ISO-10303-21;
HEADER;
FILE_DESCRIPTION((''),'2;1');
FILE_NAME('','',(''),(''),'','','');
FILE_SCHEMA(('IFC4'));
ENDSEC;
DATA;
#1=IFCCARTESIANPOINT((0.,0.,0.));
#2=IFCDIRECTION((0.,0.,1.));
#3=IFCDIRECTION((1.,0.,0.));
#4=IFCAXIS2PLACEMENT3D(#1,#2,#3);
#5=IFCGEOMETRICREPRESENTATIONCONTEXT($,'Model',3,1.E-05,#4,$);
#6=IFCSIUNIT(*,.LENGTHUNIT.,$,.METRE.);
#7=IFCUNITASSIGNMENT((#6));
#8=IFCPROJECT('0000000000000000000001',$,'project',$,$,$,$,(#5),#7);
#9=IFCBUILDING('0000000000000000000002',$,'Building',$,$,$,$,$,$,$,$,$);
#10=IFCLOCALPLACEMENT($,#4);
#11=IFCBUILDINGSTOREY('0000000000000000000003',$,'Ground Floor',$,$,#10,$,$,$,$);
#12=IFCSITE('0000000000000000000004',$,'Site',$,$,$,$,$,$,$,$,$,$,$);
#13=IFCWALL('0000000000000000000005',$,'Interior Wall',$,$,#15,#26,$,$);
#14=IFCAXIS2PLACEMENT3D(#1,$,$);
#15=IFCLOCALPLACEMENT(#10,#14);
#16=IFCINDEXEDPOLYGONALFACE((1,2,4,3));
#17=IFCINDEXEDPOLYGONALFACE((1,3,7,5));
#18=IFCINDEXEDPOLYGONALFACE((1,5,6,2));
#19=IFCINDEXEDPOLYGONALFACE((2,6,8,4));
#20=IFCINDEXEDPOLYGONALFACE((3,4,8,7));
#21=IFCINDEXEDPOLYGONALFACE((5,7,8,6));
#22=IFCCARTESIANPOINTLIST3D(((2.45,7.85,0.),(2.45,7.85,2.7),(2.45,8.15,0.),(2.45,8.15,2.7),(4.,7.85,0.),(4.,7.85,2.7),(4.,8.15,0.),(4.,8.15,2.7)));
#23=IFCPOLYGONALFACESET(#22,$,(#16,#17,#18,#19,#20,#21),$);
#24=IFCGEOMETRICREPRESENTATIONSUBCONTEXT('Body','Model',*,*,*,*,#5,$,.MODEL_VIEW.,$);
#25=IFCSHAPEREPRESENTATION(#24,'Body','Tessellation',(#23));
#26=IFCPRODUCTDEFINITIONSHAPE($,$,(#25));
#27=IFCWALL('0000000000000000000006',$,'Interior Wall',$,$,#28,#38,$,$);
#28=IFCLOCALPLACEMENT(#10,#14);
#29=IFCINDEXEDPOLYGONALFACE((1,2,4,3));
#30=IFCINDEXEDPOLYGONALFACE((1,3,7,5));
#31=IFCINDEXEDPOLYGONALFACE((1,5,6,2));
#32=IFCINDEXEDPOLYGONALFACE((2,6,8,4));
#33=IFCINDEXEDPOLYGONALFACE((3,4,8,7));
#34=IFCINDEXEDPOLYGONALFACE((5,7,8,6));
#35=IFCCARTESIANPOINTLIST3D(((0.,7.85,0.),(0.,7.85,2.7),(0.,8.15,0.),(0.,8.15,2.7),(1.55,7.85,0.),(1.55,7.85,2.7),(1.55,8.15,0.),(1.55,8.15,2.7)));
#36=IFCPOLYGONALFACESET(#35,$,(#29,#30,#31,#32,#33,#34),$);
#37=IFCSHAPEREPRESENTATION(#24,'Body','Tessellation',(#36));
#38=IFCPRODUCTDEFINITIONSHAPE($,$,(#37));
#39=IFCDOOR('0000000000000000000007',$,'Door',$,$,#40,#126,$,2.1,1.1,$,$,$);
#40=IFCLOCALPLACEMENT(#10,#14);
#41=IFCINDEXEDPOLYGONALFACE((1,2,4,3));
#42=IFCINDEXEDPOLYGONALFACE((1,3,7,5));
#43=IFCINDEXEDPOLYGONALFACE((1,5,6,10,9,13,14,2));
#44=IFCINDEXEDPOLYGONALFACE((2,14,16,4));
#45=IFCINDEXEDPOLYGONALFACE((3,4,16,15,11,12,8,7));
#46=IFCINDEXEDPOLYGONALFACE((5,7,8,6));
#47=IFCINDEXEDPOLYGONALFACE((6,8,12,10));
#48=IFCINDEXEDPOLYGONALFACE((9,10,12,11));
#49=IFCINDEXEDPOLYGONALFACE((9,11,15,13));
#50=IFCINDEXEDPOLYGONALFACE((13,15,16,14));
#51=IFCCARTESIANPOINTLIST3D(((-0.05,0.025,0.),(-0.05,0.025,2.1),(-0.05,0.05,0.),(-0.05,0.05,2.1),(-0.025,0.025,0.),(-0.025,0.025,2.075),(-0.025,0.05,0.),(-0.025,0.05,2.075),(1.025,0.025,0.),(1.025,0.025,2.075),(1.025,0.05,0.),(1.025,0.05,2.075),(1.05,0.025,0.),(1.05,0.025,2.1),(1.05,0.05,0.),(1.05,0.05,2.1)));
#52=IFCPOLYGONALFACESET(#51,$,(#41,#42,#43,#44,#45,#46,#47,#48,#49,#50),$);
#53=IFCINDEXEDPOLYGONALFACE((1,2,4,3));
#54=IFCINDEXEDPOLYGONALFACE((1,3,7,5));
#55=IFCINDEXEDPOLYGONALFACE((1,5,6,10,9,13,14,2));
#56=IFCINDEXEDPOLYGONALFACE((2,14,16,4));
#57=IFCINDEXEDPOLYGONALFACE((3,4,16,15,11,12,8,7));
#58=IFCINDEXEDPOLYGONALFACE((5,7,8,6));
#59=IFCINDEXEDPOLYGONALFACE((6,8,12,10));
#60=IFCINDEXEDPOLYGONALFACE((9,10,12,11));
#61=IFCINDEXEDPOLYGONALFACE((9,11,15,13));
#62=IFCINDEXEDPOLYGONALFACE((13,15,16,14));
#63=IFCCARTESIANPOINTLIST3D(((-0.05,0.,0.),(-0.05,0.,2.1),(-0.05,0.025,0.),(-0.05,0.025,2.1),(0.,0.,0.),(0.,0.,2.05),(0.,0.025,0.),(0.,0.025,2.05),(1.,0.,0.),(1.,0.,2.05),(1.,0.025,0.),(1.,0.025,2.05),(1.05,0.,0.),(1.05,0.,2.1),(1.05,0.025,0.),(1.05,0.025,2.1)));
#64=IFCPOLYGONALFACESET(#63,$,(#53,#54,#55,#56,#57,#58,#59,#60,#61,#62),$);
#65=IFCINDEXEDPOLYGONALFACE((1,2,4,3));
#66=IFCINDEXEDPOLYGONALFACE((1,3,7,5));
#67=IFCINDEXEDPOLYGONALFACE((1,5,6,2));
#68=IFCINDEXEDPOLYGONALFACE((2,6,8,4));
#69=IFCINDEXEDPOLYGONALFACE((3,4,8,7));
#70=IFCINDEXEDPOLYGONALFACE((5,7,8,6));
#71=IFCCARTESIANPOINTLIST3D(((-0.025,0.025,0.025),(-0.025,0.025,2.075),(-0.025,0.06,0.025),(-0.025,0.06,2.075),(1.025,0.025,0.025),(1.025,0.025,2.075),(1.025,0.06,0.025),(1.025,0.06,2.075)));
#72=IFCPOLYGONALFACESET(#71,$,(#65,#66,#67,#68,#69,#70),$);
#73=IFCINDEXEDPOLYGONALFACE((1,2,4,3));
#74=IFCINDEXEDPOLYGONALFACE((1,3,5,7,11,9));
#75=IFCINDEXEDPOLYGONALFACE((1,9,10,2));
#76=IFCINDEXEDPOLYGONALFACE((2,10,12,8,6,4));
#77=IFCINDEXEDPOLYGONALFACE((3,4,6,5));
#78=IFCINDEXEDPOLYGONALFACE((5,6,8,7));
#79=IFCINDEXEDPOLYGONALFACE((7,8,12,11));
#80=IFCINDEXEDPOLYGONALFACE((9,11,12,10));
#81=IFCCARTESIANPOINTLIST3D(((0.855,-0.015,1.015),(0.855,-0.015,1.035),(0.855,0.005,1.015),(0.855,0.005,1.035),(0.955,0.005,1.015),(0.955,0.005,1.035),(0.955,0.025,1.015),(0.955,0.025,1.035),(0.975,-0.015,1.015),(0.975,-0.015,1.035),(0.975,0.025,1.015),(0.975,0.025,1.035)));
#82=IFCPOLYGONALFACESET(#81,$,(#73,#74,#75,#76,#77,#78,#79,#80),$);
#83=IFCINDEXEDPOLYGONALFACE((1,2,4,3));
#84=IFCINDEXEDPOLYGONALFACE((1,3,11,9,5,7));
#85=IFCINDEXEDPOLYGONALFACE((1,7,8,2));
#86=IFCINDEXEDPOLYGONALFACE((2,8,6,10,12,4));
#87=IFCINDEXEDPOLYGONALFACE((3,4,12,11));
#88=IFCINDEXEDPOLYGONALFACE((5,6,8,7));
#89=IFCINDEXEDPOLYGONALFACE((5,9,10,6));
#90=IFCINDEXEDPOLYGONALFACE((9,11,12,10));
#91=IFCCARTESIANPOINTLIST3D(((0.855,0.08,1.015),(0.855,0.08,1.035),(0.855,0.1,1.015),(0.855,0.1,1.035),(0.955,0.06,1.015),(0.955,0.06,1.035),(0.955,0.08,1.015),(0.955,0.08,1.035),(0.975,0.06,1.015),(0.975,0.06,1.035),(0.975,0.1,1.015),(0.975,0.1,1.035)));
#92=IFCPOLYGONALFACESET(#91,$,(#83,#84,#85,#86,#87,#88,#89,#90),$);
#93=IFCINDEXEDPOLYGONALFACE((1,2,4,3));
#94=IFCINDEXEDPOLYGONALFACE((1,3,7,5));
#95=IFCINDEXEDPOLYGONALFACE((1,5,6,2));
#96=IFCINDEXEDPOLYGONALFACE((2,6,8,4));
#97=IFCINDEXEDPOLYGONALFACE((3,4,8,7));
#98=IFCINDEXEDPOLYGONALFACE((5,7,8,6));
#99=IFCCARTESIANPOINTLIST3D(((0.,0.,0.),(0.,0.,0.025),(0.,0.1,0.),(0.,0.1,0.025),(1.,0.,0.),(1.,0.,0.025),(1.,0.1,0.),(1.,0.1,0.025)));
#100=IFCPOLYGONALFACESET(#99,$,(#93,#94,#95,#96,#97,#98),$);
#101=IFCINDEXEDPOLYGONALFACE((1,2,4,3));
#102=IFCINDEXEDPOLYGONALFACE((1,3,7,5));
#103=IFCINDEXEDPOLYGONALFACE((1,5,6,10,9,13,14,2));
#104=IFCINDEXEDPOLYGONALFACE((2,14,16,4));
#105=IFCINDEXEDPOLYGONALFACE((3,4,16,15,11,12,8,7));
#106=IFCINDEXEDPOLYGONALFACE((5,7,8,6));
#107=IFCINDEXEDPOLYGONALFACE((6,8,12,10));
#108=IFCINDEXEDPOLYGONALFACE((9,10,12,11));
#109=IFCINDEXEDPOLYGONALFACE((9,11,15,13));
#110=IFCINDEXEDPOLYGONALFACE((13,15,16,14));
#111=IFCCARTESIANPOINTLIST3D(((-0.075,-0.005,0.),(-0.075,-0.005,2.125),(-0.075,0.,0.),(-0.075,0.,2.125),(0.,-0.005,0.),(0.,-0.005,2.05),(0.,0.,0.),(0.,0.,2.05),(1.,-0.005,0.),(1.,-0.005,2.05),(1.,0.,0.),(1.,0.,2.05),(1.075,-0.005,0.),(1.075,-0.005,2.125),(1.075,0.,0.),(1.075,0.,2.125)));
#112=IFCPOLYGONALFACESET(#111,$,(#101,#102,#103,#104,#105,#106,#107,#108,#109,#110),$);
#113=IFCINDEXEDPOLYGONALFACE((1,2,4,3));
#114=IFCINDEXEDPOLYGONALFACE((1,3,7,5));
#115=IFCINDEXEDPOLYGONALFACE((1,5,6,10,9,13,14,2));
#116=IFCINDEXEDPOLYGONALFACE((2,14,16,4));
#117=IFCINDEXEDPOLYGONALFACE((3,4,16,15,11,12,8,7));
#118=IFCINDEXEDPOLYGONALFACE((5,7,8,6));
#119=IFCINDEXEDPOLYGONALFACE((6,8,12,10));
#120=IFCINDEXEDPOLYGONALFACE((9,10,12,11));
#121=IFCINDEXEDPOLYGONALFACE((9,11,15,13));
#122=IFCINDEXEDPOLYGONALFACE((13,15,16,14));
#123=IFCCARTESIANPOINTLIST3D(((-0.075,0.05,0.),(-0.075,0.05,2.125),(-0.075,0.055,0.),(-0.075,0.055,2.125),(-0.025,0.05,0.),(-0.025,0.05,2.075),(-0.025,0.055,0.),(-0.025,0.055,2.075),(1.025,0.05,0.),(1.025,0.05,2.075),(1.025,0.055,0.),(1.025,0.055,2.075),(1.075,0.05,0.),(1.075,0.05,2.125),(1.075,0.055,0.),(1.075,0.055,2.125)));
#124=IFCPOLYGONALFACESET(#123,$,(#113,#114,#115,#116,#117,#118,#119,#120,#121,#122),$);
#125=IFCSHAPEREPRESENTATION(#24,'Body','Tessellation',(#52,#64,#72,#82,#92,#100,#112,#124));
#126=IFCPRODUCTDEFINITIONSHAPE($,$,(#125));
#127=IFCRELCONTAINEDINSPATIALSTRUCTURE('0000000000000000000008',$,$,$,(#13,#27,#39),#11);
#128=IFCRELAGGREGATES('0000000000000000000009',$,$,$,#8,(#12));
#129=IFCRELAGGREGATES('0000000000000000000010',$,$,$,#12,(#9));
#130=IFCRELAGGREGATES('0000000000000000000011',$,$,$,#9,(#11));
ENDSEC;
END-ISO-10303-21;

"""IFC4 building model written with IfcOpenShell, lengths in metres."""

from ifc_helpers import new_model, si_unit, frame, origin_with_axes, place, context, subcontext, project, spatial, line, indexed_curve, outline, extrude, element, save


model = new_model("IFC4")

# Units and contexts
model_context = context("Model", 3, precision=1e-05, world=origin_with_axes())
body_context = subcontext(model_context, "Body", "Model", "MODEL_VIEW")
ifc_project = project(units=[si_unit("LENGTHUNIT", "METRE")], contexts=[model_context])

# Site, building, storey
site = spatial("IfcSite", under=ifc_project, Name="Site")
building = spatial("IfcBuilding", under=site, Name="Building")
storey_placement = place(None, origin_with_axes())
storey = spatial("IfcBuildingStorey", under=building, at=storey_placement, Name="Ground Floor")

# Walls
for number, where, z_axis, x_axis, name in (
    (1, (4.0, 8.0, 0.0), (0.0, 0.0, 1.0), (-1.0, 0.0, 0.0), "Interior Wall"),
    (2, (1.55, 8.0, 0.0), (0.0, 0.0, 1.0), (-1.0, 0.0, 0.0), "Interior Wall"),
):
    element("IfcWall", number, at=place(storey_placement, frame(where, z_axis=z_axis, x_axis=x_axis)), inside=storey, Name=name, context=body_context, shape_type="SweptSolid", body=[
        extrude(outline(indexed_curve([(0.0, 0.0), (0.0, 0.3), (1.55, 0.3), (1.55, 0.0), (0.0, 0.0)], self_intersect=False)), frame((0.0, -0.15, 0.0), z_axis=(0.0, 0.0, 1.0), x_axis=(1.0, 0.0, 0.0)), (0.0, 0.0, 1.0), 2.7),
    ])

# Door
door_1_placement = place(storey_placement, frame((-0.05, 0.0, 0.0), z_axis=(0.0, 0.0, 1.0), x_axis=(1.0, 0.0, 0.0)))
element("IfcDoor", 3, at=door_1_placement, inside=storey, Name="Door", OverallHeight=2.1, OverallWidth=1.1, context=body_context, shape_type="SweptSolid", body=[
    extrude(outline(indexed_curve([(0.0, 0.0), (0.0, 2.1), (1.1, 2.1), (1.1, 0.0), (1.075, 0.0), (1.075, 2.075), (0.025, 2.075), (0.025, 0.0)], segments=[line(1, 2, 3, 4, 5, 6, 7, 8, 1)])), frame((0.0, 0.025, 0.0), z_axis=(0.0, -1.0, 0.0), x_axis=(1.0, 0.0, 0.0)), (0.0, 0.0, -1.0), 0.025),
    extrude(outline(indexed_curve([(0.0, 0.0), (0.0, 2.1), (1.1, 2.1), (1.1, 0.0), (1.05, 0.0), (1.05, 2.05), (0.05, 2.05), (0.05, 0.0)], segments=[line(1, 2, 3, 4, 5, 6, 7, 8, 1)])), frame((0.0, 0.0, 0.0), z_axis=(0.0, -1.0, 0.0), x_axis=(1.0, 0.0, 0.0)), (0.0, 0.0, -1.0), 0.025),
    extrude(outline(indexed_curve([(0.0, 0.0), (1.05, 0.0), (1.05, 0.035), (0.0, 0.035)], segments=[line(1, 2, 3, 4, 1)])), frame((0.025, 0.025, 0.025), z_axis=(0.0, 0.0, 1.0), x_axis=(1.0, 0.0, 0.0)), (0.0, 0.0, 1.0), 2.05),
    extrude(outline(indexed_curve([(0.0, 0.0), (0.0, -0.04), (-0.12, -0.04), (-0.12, -0.02), (-0.02, -0.02), (-0.02, 0.0)], segments=[line(1, 2, 3, 4, 5, 6, 1)])), frame((1.025, 0.025, 1.015), z_axis=(0.0, 0.0, 1.0), x_axis=(1.0, 0.0, 0.0)), (0.0, 0.0, 1.0), 0.02),
    extrude(outline(indexed_curve([(0.0, 0.0), (0.0, 0.04), (-0.12, 0.04), (-0.12, 0.02), (-0.02, 0.02), (-0.02, 0.0)], segments=[line(1, 2, 3, 4, 5, 6, 1)])), frame((1.025, 0.06, 1.015), z_axis=(0.0, 0.0, 1.0), x_axis=(1.0, 0.0, 0.0)), (0.0, 0.0, 1.0), 0.02),
    extrude(outline(indexed_curve([(0.0, 0.0), (1.0, 0.0), (1.0, 0.1), (0.0, 0.1)], segments=[line(1, 2, 3, 4, 1)])), frame((0.05, 0.0, 0.0), z_axis=(0.0, 0.0, 1.0), x_axis=(1.0, 0.0, 0.0)), (0.0, 0.0, 1.0), 0.025),
    extrude(outline(indexed_curve([(0.0, 0.0), (0.0, 2.125), (1.15, 2.125), (1.15, 0.0), (1.075, 0.0), (1.075, 2.05), (0.075, 2.05), (0.075, 0.0)], segments=[line(1, 2, 3, 4, 5, 6, 7, 8, 1)])), frame((-0.025, -0.005, 0.0), z_axis=(0.0, -1.0, 0.0), x_axis=(1.0, 0.0, 0.0)), (0.0, 0.0, -1.0), 0.005),
    extrude(outline(indexed_curve([(0.0, 0.0), (0.0, 2.125), (1.15, 2.125), (1.15, 0.0), (1.1, 0.0), (1.1, 2.075), (0.05, 2.075), (0.05, 0.0)], segments=[line(1, 2, 3, 4, 5, 6, 7, 8, 1)])), frame((-0.025, 0.05, 0.0), z_axis=(0.0, -1.0, 0.0), x_axis=(1.0, 0.0, 0.0)), (0.0, 0.0, -1.0), 0.005),
])

save(model, "model.ifc")
